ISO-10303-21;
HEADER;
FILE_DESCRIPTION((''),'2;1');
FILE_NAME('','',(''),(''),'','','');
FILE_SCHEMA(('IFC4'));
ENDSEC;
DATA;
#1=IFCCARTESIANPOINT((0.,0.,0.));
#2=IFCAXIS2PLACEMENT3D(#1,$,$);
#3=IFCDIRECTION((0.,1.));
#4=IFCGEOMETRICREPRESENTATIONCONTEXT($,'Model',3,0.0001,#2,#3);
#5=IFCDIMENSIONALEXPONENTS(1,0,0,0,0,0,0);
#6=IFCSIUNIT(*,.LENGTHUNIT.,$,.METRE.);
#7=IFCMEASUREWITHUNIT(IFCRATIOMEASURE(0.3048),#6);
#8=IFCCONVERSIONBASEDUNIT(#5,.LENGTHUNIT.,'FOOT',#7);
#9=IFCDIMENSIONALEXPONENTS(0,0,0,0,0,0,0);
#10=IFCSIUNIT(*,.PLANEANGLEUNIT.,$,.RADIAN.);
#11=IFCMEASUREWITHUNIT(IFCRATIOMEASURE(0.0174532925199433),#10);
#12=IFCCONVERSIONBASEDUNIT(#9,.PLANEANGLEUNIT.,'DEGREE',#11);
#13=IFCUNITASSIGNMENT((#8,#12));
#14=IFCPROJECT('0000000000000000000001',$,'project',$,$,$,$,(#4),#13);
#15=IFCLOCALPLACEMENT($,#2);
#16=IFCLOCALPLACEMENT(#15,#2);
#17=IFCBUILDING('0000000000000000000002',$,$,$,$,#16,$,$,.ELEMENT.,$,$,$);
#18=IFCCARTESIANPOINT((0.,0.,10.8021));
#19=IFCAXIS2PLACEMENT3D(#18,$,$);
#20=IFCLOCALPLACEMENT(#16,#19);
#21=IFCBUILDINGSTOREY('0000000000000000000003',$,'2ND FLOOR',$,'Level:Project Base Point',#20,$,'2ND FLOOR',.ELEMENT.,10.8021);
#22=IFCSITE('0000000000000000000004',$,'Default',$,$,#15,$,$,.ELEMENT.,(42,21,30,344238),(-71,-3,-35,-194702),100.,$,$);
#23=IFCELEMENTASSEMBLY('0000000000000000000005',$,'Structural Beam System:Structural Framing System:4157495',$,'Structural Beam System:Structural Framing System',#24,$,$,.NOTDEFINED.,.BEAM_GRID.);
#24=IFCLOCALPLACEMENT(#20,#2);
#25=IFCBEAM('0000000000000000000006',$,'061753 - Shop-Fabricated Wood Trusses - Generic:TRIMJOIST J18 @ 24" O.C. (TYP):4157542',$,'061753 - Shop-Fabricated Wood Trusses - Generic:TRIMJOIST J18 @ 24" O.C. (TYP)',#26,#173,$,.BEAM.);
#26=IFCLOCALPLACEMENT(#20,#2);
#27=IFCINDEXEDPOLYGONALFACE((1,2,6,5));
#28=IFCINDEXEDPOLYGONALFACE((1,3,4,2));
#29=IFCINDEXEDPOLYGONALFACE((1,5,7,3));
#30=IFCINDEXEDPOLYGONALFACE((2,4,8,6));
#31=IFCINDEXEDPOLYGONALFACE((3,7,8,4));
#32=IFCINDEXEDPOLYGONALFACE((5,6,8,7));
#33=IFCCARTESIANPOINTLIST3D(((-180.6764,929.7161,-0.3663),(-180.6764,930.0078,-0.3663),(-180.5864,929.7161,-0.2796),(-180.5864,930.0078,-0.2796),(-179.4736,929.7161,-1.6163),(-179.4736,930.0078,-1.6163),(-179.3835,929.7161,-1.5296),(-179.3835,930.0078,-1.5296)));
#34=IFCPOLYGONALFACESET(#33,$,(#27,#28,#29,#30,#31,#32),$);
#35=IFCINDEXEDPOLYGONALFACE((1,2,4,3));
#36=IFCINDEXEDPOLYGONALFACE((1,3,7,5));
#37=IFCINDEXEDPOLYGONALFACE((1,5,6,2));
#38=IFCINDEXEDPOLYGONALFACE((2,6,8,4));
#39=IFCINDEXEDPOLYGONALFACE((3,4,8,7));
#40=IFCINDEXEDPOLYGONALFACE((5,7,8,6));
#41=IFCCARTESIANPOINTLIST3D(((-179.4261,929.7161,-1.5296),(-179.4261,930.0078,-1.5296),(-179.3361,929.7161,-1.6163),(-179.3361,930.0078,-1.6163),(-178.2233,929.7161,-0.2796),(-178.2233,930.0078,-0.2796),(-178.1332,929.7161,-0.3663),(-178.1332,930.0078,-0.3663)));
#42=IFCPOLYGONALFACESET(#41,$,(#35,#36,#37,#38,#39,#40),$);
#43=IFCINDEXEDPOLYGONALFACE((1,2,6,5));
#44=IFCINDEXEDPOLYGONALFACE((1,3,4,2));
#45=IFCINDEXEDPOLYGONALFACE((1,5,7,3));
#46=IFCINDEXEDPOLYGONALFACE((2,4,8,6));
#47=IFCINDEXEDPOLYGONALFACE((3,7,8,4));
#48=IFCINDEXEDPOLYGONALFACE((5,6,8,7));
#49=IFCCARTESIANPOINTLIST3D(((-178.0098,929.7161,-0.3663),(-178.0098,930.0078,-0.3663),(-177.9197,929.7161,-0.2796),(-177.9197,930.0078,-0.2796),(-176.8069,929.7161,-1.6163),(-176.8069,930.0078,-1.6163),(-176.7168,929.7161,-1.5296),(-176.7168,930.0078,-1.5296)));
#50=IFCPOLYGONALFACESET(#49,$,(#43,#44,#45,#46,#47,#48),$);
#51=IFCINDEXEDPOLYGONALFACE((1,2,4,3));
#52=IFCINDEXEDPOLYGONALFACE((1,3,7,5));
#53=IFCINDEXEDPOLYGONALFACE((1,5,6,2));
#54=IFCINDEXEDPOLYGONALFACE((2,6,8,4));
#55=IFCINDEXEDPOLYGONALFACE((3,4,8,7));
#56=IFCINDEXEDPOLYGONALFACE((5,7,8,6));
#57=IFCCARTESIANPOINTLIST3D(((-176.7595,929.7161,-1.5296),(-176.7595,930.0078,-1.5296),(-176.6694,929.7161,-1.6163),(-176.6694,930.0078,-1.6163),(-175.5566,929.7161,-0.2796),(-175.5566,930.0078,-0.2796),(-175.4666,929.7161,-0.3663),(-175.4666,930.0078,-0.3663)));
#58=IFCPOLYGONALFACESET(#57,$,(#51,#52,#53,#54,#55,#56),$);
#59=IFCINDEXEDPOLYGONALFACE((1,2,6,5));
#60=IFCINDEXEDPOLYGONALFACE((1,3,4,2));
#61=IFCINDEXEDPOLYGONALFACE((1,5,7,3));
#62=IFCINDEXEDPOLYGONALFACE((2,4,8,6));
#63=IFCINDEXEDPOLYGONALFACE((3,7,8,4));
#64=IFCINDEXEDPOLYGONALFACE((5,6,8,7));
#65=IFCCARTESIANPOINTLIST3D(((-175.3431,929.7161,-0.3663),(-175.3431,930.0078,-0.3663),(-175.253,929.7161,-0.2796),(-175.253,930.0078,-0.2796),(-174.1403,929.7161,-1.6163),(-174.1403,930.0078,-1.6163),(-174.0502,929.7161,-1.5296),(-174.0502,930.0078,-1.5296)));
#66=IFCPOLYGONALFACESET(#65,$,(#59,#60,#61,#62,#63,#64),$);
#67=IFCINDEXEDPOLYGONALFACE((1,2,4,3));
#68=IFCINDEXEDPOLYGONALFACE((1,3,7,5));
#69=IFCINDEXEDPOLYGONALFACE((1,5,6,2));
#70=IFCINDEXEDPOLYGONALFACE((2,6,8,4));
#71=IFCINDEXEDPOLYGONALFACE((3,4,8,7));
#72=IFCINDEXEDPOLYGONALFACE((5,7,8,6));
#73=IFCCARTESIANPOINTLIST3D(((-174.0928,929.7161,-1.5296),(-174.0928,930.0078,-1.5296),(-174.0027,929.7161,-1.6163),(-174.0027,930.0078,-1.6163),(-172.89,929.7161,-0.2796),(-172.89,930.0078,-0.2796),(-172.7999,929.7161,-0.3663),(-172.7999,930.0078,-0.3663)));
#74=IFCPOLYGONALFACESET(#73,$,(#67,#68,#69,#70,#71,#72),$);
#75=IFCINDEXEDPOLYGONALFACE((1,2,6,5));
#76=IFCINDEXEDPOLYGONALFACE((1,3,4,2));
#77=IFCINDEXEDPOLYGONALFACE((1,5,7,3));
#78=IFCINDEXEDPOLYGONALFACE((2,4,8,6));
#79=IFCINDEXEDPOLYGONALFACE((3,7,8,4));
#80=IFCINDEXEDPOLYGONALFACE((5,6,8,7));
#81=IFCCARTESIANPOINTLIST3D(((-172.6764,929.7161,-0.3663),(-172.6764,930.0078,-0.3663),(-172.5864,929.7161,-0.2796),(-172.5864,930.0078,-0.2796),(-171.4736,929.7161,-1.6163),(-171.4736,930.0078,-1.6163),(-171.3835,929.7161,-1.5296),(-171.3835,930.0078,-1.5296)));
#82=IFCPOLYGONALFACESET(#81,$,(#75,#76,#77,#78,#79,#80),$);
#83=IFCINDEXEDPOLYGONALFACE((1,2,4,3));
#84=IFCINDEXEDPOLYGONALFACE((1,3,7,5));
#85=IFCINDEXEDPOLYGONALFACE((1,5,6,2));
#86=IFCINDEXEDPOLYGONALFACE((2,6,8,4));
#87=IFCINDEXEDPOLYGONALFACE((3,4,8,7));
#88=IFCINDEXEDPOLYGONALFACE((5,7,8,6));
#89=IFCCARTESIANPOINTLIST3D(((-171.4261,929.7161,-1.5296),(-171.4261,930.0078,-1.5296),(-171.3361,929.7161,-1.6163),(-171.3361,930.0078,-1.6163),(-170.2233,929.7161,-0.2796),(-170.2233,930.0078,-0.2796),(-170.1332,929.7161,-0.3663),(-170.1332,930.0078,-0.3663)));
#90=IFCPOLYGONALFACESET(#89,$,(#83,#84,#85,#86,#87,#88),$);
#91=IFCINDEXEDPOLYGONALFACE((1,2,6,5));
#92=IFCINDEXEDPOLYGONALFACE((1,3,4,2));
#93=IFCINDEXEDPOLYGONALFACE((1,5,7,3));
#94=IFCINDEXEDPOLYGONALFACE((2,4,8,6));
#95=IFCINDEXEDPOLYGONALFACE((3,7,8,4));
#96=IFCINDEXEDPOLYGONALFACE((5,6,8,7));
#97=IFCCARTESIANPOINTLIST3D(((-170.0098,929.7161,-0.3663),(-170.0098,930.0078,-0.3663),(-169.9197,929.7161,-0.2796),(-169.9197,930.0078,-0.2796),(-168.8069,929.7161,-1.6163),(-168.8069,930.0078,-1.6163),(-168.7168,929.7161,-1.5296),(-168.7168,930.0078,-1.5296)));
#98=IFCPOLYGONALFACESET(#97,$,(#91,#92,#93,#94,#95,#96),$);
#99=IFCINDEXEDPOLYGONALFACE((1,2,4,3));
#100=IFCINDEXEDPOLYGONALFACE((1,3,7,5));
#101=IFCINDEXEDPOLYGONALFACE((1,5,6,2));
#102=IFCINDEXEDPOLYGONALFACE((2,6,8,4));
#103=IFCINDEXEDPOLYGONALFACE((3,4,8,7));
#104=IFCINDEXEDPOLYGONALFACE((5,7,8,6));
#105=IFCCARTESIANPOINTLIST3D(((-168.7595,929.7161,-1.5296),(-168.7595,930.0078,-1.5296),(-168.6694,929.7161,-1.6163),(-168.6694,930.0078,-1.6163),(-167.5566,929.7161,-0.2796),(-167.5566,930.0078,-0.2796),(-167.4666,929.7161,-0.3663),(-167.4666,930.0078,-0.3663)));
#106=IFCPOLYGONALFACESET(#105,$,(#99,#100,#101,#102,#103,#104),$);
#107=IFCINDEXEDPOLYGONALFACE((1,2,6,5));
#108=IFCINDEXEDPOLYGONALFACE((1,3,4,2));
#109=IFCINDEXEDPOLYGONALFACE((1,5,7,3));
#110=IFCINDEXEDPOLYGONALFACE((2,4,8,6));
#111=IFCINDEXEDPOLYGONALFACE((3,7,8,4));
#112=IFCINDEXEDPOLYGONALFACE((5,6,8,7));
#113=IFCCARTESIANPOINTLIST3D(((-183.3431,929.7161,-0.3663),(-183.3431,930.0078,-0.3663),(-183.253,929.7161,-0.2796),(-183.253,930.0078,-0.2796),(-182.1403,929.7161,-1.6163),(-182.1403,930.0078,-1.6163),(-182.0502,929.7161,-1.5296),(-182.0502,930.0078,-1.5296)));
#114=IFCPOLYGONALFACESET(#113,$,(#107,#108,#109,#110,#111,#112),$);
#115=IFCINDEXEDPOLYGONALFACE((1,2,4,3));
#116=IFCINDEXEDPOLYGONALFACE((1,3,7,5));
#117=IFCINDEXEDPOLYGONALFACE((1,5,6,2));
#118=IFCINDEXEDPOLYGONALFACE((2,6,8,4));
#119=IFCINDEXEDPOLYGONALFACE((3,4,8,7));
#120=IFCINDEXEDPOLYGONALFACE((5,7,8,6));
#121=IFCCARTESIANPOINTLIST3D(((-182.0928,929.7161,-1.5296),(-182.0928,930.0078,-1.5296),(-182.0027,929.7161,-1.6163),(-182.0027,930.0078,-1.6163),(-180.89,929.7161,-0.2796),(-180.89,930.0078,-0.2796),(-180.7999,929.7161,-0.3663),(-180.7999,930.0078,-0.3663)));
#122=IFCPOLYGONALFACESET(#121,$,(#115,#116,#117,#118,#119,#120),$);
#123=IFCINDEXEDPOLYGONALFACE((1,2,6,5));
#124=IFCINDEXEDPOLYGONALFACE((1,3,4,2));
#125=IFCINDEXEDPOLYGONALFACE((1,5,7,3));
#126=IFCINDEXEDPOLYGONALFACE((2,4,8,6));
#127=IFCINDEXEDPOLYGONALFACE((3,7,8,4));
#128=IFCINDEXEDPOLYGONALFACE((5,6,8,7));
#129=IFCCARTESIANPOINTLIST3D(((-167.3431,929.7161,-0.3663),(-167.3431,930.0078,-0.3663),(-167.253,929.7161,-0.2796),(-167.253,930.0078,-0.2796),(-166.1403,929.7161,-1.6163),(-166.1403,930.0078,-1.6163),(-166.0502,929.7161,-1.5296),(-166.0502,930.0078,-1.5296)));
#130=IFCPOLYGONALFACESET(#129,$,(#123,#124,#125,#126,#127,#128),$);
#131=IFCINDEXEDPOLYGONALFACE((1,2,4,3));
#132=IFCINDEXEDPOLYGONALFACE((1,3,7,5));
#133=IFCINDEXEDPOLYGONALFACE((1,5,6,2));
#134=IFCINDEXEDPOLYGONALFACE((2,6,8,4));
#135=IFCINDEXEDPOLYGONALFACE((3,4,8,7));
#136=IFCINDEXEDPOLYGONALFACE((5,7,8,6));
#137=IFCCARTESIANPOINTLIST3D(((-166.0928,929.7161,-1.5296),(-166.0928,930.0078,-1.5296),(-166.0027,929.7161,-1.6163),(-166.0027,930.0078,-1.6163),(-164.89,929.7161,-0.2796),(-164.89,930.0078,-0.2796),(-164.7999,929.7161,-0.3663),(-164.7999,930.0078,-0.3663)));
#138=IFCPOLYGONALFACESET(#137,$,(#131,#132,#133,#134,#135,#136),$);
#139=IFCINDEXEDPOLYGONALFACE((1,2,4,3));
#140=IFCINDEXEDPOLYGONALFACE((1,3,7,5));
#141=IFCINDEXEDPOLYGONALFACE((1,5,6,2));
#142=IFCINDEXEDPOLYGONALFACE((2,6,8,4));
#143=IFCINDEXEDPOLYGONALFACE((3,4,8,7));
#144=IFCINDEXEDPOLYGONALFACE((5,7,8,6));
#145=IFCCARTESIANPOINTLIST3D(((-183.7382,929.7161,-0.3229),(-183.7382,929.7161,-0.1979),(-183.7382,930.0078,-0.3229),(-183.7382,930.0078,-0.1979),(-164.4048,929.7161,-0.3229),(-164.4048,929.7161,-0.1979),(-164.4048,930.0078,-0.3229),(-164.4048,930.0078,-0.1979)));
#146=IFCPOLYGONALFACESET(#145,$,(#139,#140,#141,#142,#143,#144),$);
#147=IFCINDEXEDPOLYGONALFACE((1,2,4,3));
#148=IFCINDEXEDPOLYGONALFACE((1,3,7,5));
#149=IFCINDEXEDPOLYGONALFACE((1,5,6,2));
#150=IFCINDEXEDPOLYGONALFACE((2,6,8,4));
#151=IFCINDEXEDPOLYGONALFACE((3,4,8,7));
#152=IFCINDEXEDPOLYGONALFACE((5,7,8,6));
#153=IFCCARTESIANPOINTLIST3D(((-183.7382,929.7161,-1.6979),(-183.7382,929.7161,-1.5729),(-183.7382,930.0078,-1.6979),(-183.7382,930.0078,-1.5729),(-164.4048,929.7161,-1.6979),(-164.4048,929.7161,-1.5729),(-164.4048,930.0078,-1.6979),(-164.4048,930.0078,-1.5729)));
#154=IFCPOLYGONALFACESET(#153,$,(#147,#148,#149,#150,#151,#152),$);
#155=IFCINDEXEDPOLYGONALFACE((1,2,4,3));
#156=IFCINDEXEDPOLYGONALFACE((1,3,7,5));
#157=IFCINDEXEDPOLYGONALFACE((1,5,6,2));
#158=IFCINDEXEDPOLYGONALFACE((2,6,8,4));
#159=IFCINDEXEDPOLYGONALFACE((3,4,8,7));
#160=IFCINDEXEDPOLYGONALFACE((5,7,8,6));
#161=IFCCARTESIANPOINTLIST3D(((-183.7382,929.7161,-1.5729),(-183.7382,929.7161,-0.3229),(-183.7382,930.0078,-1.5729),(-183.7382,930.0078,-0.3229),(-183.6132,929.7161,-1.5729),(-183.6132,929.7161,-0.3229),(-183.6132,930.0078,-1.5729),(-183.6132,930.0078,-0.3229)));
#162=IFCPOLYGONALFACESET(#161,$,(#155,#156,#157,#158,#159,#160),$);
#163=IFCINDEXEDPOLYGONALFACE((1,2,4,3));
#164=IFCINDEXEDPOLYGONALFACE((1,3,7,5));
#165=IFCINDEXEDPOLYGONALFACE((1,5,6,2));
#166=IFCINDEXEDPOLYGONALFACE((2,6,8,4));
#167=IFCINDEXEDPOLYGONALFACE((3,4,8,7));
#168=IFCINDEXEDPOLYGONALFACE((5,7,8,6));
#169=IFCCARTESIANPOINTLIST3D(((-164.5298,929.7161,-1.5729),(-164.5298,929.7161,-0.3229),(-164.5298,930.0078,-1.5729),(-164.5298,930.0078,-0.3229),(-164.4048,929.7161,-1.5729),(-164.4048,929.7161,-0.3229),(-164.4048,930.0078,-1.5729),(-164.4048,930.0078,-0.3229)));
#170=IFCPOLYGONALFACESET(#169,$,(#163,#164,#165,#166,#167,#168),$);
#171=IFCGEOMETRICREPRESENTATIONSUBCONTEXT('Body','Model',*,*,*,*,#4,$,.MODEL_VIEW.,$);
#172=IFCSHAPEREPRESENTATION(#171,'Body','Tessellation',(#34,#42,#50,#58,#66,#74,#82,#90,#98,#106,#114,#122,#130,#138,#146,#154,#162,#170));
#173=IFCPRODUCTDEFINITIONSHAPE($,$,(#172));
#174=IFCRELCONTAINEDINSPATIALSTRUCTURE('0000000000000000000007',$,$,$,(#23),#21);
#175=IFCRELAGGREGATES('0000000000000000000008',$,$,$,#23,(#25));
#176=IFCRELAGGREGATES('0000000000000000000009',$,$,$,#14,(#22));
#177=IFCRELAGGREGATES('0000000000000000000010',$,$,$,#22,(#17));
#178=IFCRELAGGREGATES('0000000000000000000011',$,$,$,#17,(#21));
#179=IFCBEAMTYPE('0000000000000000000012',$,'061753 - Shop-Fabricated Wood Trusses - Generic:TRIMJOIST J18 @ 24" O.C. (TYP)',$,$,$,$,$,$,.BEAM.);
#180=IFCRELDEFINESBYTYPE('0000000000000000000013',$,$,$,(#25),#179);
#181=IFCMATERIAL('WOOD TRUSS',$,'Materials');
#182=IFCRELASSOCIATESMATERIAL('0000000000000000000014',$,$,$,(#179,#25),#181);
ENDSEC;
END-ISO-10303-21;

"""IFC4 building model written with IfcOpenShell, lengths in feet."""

from ifc_helpers import new_model, entity, si_unit, converted_unit, direction, frame, frame_2d, origin, origin_2d_with_axis, place, context, subcontext, project, spatial, rectangle, extrude, source, transform, mapped, material, material_profile, profile_set, profile_usage, type_object, type_shapes, element, aggregate, save


model = new_model("IFC4")

# Units and contexts
model_context = context("Model", 3, precision=0.0001, world=origin(), true_north=direction((0.0, 1.0)))
body_context = subcontext(model_context, "Body", "Model", "MODEL_VIEW")
ifc_project = project(units=[converted_unit("LENGTHUNIT", "FOOT", entity("IfcRatioMeasure", 0.3048), si_unit("LENGTHUNIT", "METRE"), dimensions=[1, 0, 0, 0, 0, 0, 0]), converted_unit("PLANEANGLEUNIT", "DEGREE", entity("IfcRatioMeasure", 0.0174532925199433), si_unit("PLANEANGLEUNIT", "RADIAN"), dimensions=[0, 0, 0, 0, 0, 0, 0])], contexts=[model_context])

# Site, building, storey
site_placement = place(None, origin())
site = spatial("IfcSite", under=ifc_project, at=site_placement, Name="Default", CompositionType="ELEMENT", RefLatitude=(42, 21, 30, 344238), RefLongitude=(-71, -3, -35, -194702), RefElevation=100.0)
building_placement = place(site_placement, origin())
building = spatial("IfcBuilding", under=site, at=building_placement, CompositionType="ELEMENT")
storey_placement = place(building_placement, frame((0.0, 0.0, 10.8021)))
storey = spatial("IfcBuildingStorey", under=building, at=storey_placement, Name="2ND FLOOR", ObjectType="Level:Project Base Point", LongName="2ND FLOOR", CompositionType="ELEMENT", Elevation=10.8021)

# Element assembly, beam
ifc_material_1 = material(Name="WOOD TRUSS", Category="Materials")
ifc_material_profile_1 = material_profile(ifc_material_1, rectangle(XDim=1.7347, YDim=0.125, at=frame_2d((0.0, 0.0), x_axis=(1.0, 0.0))), Name="TRIMJOIST J18 @ 24\" O.C. (TYP)")
ifc_material_profile_2 = material_profile(ifc_material_1, rectangle(XDim=1.7347, YDim=0.125, at=frame_2d((0.0, 0.0), x_axis=(1.0, 0.0))), Name="TRIMJOIST J18 @ 24\" O.C. (TYP)")
ifc_material_profile_3 = material_profile(ifc_material_1, rectangle(XDim=1.7347, YDim=0.125, at=frame_2d((0.0, 0.0), x_axis=(1.0, 0.0))), Name="TRIMJOIST J18 @ 24\" O.C. (TYP)")
ifc_material_profile_4 = material_profile(ifc_material_1, rectangle(XDim=1.7347, YDim=0.125, at=frame_2d((0.0, 0.0), x_axis=(1.0, 0.0))), Name="TRIMJOIST J18 @ 24\" O.C. (TYP)")
ifc_material_profile_5 = material_profile(ifc_material_1, rectangle(XDim=1.7347, YDim=0.125, at=frame_2d((0.0, 0.0), x_axis=(1.0, 0.0))), Name="TRIMJOIST J18 @ 24\" O.C. (TYP)")
ifc_material_profile_6 = material_profile(ifc_material_1, rectangle(XDim=1.7347, YDim=0.125, at=frame_2d((0.0, 0.0), x_axis=(1.0, 0.0))), Name="TRIMJOIST J18 @ 24\" O.C. (TYP)")
ifc_material_profile_7 = material_profile(ifc_material_1, rectangle(XDim=1.7347, YDim=0.125, at=frame_2d((0.0, 0.0), x_axis=(1.0, 0.0))), Name="TRIMJOIST J18 @ 24\" O.C. (TYP)")
ifc_material_profile_8 = material_profile(ifc_material_1, rectangle(XDim=1.7347, YDim=0.125, at=frame_2d((0.0, 0.0), x_axis=(1.0, 0.0))), Name="TRIMJOIST J18 @ 24\" O.C. (TYP)")
ifc_material_profile_9 = material_profile(ifc_material_1, rectangle(XDim=1.7347, YDim=0.125, at=frame_2d((0.0, 0.0), x_axis=(1.0, 0.0))), Name="TRIMJOIST J18 @ 24\" O.C. (TYP)")
ifc_material_profile_10 = material_profile(ifc_material_1, rectangle(XDim=1.7347, YDim=0.125, at=origin_2d_with_axis()), Name="TRIMJOIST J18 @ 24\" O.C. (TYP)")
ifc_material_profile_11 = material_profile(ifc_material_1, rectangle(XDim=0.125, YDim=0.2917, at=origin_2d_with_axis()), Name="TRIMJOIST J18 @ 24\" O.C. (TYP)")
ifc_material_profile_12 = material_profile(ifc_material_1, rectangle(XDim=0.125, YDim=0.2917, at=origin_2d_with_axis()), Name="TRIMJOIST J18 @ 24\" O.C. (TYP)")
ifc_material_profile_13 = material_profile(ifc_material_1, rectangle(XDim=1.25, YDim=0.2917, at=origin_2d_with_axis()), Name="TRIMJOIST J18 @ 24\" O.C. (TYP)")
ifc_material_profile_14 = material_profile(ifc_material_1, rectangle(XDim=1.25, YDim=0.2917, at=origin_2d_with_axis()), Name="TRIMJOIST J18 @ 24\" O.C. (TYP)")
ifc_profile_set_1 = profile_set([ifc_material_profile_1, ifc_material_profile_2, ifc_material_profile_3, ifc_material_profile_4, ifc_material_profile_5, ifc_material_profile_6, ifc_material_profile_7, ifc_material_profile_8, ifc_material_profile_9, ifc_material_profile_10, ifc_material_profile_11, ifc_material_profile_12, ifc_material_profile_13, ifc_material_profile_14], Name="TRIMJOIST J18 @ 24\" O.C. (TYP)")
assembly_1_placement = place(storey_placement, origin())
assembly_1 = element("IfcElementAssembly", 1, at=assembly_1_placement, inside=storey, Name="Structural Beam System:Structural Framing System:4157495", ObjectType="Structural Beam System:Structural Framing System", AssemblyPlace="NOTDEFINED", PredefinedType="BEAM_GRID")
beam_type_1 = type_object("IfcBeamType", Name="061753 - Shop-Fabricated Wood Trusses - Generic:TRIMJOIST J18 @ 24\" O.C. (TYP)", PredefinedType="BEAM", material=ifc_profile_set_1)
shared_shape_1 = source(origin(), body_context, "Body", "SweptSolid", [
    extrude(rectangle(XDim=1.7347, YDim=0.125, at=frame_2d((0.0, 0.0), x_axis=(1.0, 0.0))), frame((5.9585, -0.1458, 0.0), z_axis=(0.0, 1.0, 0.0), x_axis=(0.693383, 0.0, 0.720569)), (0.0, 0.0, 1.0), 0.2917),
    extrude(rectangle(XDim=1.7347, YDim=0.125, at=origin_2d_with_axis()), frame((4.7082, -0.1458, 0.0), z_axis=(0.0, 1.0, 0.0), x_axis=(0.693383, 0.0, -0.720569)), (0.0, 0.0, 1.0), 0.2917),
    extrude(rectangle(XDim=1.7347, YDim=0.125, at=frame_2d((0.0, 0.0), x_axis=(1.0, 0.0))), frame((3.2918, -0.1458, 0.0), z_axis=(0.0, 1.0, 0.0), x_axis=(0.693383, 0.0, 0.720569)), (0.0, 0.0, 1.0), 0.2917),
    extrude(rectangle(XDim=1.7347, YDim=0.125, at=frame_2d((0.0, 0.0), x_axis=(1.0, 0.0))), frame((2.0415, -0.1458, 0.0), z_axis=(0.0, 1.0, 0.0), x_axis=(0.693383, 0.0, -0.720569)), (0.0, 0.0, 1.0), 0.2917),
    extrude(rectangle(XDim=1.7347, YDim=0.125, at=frame_2d((0.0, 0.0), x_axis=(1.0, 0.0))), frame((0.6251, -0.1458, 0.0), z_axis=(0.0, 1.0, 0.0), x_axis=(0.693383, 0.0, 0.720569)), (0.0, 0.0, 1.0), 0.2917),
    extrude(rectangle(XDim=1.7347, YDim=0.125, at=frame_2d((0.0, 0.0), x_axis=(1.0, 0.0))), frame((-0.6251, -0.1458, 0.0), z_axis=(0.0, 1.0, 0.0), x_axis=(0.693383, 0.0, -0.720569)), (0.0, 0.0, 1.0), 0.2917),
    extrude(rectangle(XDim=1.7347, YDim=0.125, at=frame_2d((0.0, 0.0), x_axis=(1.0, 0.0))), frame((-2.0415, -0.1458, 0.0), z_axis=(0.0, 1.0, 0.0), x_axis=(0.693383, 0.0, 0.720569)), (0.0, 0.0, 1.0), 0.2917),
    extrude(rectangle(XDim=1.7347, YDim=0.125, at=origin_2d_with_axis()), frame((-3.2918, -0.1458, 0.0), z_axis=(0.0, 1.0, 0.0), x_axis=(0.693383, 0.0, -0.720569)), (0.0, 0.0, 1.0), 0.2917),
    extrude(rectangle(XDim=1.7347, YDim=0.125, at=frame_2d((0.0, 0.0), x_axis=(1.0, 0.0))), frame((-4.7082, -0.1458, 0.0), z_axis=(0.0, 1.0, 0.0), x_axis=(0.693383, 0.0, 0.720569)), (0.0, 0.0, 1.0), 0.2917),
    extrude(rectangle(XDim=1.7347, YDim=0.125, at=frame_2d((0.0, 0.0), x_axis=(1.0, 0.0))), frame((-5.9585, -0.1458, 0.0), z_axis=(0.0, 1.0, 0.0), x_axis=(0.693383, 0.0, -0.720569)), (0.0, 0.0, 1.0), 0.2917),
    extrude(rectangle(XDim=1.7347, YDim=0.125, at=frame_2d((0.0, 0.0), x_axis=(1.0, 0.0))), frame((8.6251, -0.1458, 0.0), z_axis=(0.0, 1.0, 0.0), x_axis=(0.693383, 0.0, 0.720569)), (0.0, 0.0, 1.0), 0.2917),
    extrude(rectangle(XDim=1.7347, YDim=0.125, at=origin_2d_with_axis()), frame((7.3749, -0.1458, 0.0), z_axis=(0.0, 1.0, 0.0), x_axis=(0.693383, 0.0, -0.720569)), (0.0, 0.0, 1.0), 0.2917),
    extrude(rectangle(XDim=1.7347, YDim=0.125, at=frame_2d((0.0, 0.0), x_axis=(1.0, 0.0))), frame((-7.3749, -0.1458, 0.0), z_axis=(0.0, 1.0, 0.0), x_axis=(0.693383, 0.0, 0.720569)), (0.0, 0.0, 1.0), 0.2917),
    extrude(rectangle(XDim=1.7347, YDim=0.125, at=origin_2d_with_axis()), frame((-8.6251, -0.1458, 0.0), z_axis=(0.0, 1.0, 0.0), x_axis=(0.693383, 0.0, -0.720569)), (0.0, 0.0, 1.0), 0.2917),
    extrude(rectangle(XDim=0.125, YDim=0.2917, at=origin_2d_with_axis()), frame((-9.6667, 0.0, 0.6875), z_axis=(1.0, 0.0, 0.0), x_axis=(0.0, 0.0, -1.0)), (0.0, 0.0, 1.0), 19.3333),
    extrude(rectangle(XDim=0.125, YDim=0.2917, at=origin_2d_with_axis()), frame((-9.6667, 0.0, -0.6875), z_axis=(1.0, 0.0, 0.0), x_axis=(0.0, 0.0, -1.0)), (0.0, 0.0, 1.0), 19.3333),
    extrude(rectangle(XDim=1.25, YDim=0.2917, at=origin_2d_with_axis()), frame((9.5417, 0.0, 0.0), z_axis=(1.0, 0.0, 0.0), x_axis=(0.0, 0.0, -1.0)), (0.0, 0.0, 1.0), 0.125),
    extrude(rectangle(XDim=1.25, YDim=0.2917, at=origin_2d_with_axis()), frame((-9.6667, 0.0, 0.0), z_axis=(1.0, 0.0, 0.0), x_axis=(0.0, 0.0, -1.0)), (0.0, 0.0, 1.0), 0.125),
])
type_shapes(beam_type_1, [shared_shape_1])
ifc_profile_usage_1 = profile_usage(ifc_profile_set_1, cardinal=8)
beam_1_placement = place(assembly_1_placement, frame((-174.0715, 929.8619, -0.9479), z_axis=(0.0, 0.0, 1.0), x_axis=(-1.0, 0.0, 0.0)))
beam_1 = element("IfcBeam", 2, at=beam_1_placement, type_object=beam_type_1, material=ifc_profile_usage_1, Name="061753 - Shop-Fabricated Wood Trusses - Generic:TRIMJOIST J18 @ 24\" O.C. (TYP):4157542", ObjectType="061753 - Shop-Fabricated Wood Trusses - Generic:TRIMJOIST J18 @ 24\" O.C. (TYP)", PredefinedType="BEAM", context=body_context, shape_type="MappedRepresentation", body=[
    mapped(shared_shape_1, transform((0.0, 0.0, 0.0), scale=1.0)),
])
aggregate(assembly_1, [beam_1])

save(model, "model.ifc")
